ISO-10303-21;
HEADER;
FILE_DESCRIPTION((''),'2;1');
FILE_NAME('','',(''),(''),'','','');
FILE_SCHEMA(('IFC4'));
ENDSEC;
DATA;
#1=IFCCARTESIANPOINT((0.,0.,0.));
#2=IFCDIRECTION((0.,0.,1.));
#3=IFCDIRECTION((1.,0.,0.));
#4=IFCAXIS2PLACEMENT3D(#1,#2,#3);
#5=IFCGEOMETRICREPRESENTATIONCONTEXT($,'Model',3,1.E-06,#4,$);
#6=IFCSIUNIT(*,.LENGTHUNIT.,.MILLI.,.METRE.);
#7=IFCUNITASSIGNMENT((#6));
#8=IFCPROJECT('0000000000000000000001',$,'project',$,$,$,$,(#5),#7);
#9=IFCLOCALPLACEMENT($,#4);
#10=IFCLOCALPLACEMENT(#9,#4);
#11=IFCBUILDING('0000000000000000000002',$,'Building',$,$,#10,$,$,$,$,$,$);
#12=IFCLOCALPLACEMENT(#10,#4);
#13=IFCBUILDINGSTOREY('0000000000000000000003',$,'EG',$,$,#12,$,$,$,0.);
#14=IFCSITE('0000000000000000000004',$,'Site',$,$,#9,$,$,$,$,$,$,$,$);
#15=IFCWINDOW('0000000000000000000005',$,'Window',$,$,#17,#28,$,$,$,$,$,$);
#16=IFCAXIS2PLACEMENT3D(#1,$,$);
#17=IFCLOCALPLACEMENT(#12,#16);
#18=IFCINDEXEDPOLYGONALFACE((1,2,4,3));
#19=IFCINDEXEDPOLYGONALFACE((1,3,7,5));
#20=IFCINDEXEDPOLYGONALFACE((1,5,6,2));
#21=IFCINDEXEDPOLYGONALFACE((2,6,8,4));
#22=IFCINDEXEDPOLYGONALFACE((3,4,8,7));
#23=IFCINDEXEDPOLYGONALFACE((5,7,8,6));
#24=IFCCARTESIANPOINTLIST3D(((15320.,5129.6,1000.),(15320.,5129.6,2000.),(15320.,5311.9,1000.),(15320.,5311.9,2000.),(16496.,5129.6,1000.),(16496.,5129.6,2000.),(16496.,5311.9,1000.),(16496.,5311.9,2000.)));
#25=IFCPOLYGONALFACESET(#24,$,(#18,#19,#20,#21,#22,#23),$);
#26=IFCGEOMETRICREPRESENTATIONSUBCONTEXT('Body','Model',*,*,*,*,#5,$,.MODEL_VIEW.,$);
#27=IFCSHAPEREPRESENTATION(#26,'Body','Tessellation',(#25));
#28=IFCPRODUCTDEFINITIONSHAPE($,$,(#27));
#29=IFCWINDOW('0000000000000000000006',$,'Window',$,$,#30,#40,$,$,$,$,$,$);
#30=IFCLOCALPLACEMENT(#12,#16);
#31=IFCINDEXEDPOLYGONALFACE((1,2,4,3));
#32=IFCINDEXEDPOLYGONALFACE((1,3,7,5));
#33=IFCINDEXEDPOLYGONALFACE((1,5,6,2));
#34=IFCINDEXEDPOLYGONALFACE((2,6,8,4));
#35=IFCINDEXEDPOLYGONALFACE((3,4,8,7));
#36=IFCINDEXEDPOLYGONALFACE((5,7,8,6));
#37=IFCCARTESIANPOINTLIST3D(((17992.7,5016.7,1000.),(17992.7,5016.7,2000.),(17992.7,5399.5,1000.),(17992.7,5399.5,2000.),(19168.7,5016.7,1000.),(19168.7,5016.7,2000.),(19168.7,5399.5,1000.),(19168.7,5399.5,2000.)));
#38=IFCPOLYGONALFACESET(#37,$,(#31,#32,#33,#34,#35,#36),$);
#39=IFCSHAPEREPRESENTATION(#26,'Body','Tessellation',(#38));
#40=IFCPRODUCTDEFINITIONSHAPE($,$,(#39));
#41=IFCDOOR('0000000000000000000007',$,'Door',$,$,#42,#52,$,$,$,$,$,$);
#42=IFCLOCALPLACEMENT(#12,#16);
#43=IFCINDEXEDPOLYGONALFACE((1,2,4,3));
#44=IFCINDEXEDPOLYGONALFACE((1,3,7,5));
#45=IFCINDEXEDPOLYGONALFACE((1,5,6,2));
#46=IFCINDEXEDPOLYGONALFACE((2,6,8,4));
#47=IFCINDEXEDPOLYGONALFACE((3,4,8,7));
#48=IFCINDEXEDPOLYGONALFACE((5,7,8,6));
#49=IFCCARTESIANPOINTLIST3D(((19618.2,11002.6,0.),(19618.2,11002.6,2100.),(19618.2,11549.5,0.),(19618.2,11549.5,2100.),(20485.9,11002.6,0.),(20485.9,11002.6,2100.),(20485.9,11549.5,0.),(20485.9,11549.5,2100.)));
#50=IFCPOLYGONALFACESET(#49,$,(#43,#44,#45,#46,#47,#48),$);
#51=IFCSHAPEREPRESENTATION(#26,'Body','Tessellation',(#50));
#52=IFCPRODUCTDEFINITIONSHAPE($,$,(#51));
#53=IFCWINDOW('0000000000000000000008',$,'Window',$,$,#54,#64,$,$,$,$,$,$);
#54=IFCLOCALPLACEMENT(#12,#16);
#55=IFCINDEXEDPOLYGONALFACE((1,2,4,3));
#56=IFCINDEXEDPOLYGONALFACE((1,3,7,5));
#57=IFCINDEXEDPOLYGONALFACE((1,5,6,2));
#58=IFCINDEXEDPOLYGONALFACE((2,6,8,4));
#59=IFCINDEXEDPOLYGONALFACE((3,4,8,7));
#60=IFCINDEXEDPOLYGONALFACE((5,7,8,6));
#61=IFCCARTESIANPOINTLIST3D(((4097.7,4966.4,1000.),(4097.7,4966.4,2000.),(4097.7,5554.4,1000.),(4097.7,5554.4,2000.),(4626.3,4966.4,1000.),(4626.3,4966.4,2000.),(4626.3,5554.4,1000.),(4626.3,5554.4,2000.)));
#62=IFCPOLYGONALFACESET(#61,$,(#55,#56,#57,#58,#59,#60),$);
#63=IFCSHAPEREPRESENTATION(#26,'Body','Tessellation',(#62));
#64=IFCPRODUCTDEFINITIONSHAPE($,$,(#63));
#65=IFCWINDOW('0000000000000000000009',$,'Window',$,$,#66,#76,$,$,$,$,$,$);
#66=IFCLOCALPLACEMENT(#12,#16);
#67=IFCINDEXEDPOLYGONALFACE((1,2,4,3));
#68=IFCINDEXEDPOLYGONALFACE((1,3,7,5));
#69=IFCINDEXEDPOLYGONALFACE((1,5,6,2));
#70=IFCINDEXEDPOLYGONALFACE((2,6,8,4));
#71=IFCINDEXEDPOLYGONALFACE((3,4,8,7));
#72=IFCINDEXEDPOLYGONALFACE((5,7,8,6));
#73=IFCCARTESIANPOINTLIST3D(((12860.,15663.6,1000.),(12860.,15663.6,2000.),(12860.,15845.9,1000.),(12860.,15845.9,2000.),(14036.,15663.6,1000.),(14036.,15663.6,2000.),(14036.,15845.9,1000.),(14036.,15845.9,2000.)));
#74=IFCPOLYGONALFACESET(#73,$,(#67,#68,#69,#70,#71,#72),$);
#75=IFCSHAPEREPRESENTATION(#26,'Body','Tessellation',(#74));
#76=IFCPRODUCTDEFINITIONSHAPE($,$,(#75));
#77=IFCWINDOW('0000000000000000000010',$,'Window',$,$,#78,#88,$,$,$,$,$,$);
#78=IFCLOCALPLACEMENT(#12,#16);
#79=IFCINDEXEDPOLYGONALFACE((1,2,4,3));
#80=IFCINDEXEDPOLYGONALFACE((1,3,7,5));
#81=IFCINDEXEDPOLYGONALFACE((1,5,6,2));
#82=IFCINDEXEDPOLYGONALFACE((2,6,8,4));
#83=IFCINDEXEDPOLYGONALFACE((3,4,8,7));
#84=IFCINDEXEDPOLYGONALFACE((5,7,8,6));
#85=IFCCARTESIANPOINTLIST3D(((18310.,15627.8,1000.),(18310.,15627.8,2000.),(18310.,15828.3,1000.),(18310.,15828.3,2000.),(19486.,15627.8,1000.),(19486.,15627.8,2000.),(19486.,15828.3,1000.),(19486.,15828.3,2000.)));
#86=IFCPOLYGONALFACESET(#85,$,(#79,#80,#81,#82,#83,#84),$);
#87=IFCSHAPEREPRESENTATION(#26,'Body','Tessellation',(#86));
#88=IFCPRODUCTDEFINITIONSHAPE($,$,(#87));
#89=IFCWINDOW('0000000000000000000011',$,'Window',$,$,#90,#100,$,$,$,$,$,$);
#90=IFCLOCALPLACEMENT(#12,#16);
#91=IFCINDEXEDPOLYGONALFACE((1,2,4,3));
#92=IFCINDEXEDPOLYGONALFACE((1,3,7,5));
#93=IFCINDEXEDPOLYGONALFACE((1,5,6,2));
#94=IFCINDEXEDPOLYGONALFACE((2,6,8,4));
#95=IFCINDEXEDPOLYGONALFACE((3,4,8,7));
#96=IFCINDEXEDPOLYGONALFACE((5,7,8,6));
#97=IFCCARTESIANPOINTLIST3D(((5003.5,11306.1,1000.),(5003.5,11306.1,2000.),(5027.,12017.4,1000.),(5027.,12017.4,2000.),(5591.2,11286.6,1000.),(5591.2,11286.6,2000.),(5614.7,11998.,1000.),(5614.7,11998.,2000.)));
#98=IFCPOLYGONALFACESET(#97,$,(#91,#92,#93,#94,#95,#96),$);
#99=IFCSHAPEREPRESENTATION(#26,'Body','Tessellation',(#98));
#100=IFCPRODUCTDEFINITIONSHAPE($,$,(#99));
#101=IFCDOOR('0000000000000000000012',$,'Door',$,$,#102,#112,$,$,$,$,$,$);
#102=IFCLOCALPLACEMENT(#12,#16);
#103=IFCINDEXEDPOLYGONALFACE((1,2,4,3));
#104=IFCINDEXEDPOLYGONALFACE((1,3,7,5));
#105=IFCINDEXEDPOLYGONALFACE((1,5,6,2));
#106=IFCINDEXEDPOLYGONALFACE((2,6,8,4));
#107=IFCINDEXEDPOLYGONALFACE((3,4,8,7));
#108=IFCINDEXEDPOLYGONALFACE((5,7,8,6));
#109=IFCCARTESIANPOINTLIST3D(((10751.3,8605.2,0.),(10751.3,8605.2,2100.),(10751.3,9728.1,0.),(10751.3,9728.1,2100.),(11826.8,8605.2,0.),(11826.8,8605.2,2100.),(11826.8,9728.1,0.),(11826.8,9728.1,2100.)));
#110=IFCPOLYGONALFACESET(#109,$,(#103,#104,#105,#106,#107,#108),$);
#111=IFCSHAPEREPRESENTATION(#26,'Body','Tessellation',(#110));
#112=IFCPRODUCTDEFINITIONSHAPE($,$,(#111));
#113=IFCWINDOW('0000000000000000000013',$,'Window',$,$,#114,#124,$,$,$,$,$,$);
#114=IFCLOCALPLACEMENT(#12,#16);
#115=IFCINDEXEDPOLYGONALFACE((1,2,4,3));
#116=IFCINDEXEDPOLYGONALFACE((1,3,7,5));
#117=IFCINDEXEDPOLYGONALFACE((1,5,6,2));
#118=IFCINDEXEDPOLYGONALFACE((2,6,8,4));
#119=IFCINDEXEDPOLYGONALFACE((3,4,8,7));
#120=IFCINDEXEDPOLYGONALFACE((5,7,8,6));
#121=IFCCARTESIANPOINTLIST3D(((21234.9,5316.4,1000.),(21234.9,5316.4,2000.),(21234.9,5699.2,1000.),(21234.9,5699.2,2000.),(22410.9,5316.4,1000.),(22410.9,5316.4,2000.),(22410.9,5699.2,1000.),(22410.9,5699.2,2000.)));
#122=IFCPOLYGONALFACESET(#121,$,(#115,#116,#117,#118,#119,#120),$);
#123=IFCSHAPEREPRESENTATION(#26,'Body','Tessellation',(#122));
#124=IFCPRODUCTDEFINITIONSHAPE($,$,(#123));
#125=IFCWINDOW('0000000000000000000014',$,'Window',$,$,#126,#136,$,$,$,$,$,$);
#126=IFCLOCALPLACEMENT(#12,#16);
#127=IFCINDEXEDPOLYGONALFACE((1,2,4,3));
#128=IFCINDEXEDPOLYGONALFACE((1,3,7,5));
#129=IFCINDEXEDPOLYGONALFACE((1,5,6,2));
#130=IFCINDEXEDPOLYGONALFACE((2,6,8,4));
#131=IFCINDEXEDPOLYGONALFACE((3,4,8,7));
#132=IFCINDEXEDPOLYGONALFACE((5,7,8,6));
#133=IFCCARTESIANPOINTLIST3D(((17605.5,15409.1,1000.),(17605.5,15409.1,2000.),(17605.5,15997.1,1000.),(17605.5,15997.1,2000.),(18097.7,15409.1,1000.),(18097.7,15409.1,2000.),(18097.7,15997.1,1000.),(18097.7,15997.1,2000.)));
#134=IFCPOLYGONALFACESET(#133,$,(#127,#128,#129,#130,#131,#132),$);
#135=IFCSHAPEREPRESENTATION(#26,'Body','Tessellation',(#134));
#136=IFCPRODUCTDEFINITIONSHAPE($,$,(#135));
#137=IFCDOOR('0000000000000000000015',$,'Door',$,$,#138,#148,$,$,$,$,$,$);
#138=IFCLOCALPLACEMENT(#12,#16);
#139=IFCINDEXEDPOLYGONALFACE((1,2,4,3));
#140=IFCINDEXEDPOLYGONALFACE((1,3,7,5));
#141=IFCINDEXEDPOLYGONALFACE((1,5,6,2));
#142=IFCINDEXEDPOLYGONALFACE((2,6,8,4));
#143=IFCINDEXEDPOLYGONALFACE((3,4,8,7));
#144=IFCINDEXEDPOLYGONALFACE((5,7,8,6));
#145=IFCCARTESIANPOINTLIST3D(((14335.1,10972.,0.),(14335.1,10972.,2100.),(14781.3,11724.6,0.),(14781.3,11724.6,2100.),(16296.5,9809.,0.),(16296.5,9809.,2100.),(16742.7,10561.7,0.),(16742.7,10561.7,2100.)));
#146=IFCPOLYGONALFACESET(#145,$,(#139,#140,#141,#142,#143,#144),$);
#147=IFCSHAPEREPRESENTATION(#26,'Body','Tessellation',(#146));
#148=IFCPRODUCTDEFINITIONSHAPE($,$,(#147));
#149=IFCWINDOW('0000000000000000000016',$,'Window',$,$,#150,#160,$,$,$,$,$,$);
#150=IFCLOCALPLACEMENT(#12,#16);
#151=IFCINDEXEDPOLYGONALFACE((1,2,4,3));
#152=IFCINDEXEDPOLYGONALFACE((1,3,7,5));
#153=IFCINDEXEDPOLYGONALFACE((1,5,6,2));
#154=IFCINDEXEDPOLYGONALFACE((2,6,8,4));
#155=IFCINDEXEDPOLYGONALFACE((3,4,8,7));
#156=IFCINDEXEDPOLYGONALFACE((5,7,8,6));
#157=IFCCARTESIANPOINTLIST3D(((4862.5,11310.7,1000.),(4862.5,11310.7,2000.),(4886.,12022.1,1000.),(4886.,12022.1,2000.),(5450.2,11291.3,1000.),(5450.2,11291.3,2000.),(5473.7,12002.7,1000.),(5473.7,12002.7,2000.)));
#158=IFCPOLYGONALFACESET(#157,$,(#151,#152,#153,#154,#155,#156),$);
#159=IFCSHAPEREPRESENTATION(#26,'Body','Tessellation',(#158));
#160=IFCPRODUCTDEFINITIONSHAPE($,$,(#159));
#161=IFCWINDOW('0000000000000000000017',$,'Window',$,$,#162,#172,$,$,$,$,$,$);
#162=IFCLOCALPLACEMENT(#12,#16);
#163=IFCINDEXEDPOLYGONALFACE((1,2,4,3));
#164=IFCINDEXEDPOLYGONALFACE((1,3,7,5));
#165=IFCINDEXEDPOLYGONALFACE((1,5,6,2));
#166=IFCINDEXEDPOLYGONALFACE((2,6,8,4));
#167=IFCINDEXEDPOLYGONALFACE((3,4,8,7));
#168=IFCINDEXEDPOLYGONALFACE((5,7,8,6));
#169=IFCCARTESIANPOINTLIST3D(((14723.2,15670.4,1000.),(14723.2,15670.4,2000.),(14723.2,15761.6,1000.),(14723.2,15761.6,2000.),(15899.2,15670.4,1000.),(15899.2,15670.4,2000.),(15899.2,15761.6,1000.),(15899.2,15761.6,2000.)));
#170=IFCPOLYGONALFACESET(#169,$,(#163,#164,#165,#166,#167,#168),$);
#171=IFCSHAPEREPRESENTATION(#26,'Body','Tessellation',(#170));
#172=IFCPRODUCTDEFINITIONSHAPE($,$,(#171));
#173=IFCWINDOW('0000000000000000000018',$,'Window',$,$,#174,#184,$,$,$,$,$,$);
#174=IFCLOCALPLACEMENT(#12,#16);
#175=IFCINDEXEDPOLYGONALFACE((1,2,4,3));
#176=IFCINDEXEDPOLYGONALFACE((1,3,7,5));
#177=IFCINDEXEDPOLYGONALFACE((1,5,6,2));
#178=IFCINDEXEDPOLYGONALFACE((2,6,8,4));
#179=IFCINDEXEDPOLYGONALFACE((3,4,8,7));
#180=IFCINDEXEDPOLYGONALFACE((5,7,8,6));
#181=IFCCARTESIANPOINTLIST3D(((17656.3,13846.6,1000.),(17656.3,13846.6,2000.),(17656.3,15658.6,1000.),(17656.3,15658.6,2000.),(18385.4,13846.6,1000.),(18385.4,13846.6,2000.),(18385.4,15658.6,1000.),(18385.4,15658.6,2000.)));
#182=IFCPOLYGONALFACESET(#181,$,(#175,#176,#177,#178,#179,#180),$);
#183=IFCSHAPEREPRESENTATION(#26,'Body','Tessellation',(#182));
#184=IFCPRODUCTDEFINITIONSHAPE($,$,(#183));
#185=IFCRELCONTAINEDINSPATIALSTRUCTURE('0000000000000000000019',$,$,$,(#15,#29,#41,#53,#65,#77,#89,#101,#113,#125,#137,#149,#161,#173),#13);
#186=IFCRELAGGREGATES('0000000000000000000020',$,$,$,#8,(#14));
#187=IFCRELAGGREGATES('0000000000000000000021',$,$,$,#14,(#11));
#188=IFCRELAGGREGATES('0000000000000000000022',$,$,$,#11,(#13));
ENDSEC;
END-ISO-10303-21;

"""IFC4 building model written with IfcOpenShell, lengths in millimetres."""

from ifc_helpers import new_model, si_unit, frame, origin_with_axes, place, context, subcontext, project, spatial, rectangle, extrude, element, save


model = new_model("IFC4")

# Units and contexts
model_context = context("Model", 3, precision=1e-06, world=origin_with_axes())
body_context = subcontext(model_context, "Body", "Model", "MODEL_VIEW")
ifc_project = project(units=[si_unit("LENGTHUNIT", "METRE", prefix="MILLI")], contexts=[model_context])

# Site, building, storey
site_placement = place(None, origin_with_axes())
site = spatial("IfcSite", under=ifc_project, at=site_placement, Name="Site")
building_placement = place(site_placement, origin_with_axes())
building = spatial("IfcBuilding", under=site, at=building_placement, Name="Building")
storey_placement = place(building_placement, origin_with_axes())
storey = spatial("IfcBuildingStorey", under=building, at=storey_placement, Name="EG", Elevation=0.0)

# Windows
window_1_placement = place(storey_placement, origin_with_axes())
element("IfcWindow", 1, at=window_1_placement, inside=storey, Name="Window", context=body_context, shape_type="SweptSolid", body=[
    extrude(rectangle(XDim=1176.0, YDim=182.3), frame((15908.0, 5220.7, 1000.0), z_axis=(0.0, 0.0, 1.0), x_axis=(1.0, 0.0, 0.0)), (0.0, 0.0, 1.0), 1000.0),
])
window_2_placement = place(storey_placement, origin_with_axes())
element("IfcWindow", 2, at=window_2_placement, inside=storey, Name="Window", context=body_context, shape_type="SweptSolid", body=[
    extrude(rectangle(XDim=1176.0, YDim=382.8), frame((18580.7, 5208.1, 1000.0), z_axis=(0.0, 0.0, 1.0), x_axis=(1.0, 0.0, 0.0)), (0.0, 0.0, 1.0), 1000.0),
])

# Door
door_1_placement = place(storey_placement, origin_with_axes())
element("IfcDoor", 3, at=door_1_placement, inside=storey, Name="Door", context=body_context, shape_type="SweptSolid", body=[
    extrude(rectangle(XDim=867.7, YDim=546.9), frame((20052.1, 11276.0, 0.0), z_axis=(0.0, 0.0, 1.0), x_axis=(1.0, 0.0, 0.0)), (0.0, 0.0, 1.0), 2100.0),
])

# Windows
window_3_placement = place(storey_placement, origin_with_axes())
element("IfcWindow", 4, at=window_3_placement, inside=storey, Name="Window", context=body_context, shape_type="SweptSolid", body=[
    extrude(rectangle(XDim=588.0, YDim=528.6), frame((4362.0, 5260.4, 1000.0), z_axis=(0.0, 0.0, 1.0), x_axis=(0.0, 1.0, 0.0)), (0.0, 0.0, 1.0), 1000.0),
])
window_4_placement = place(storey_placement, origin_with_axes())
element("IfcWindow", 5, at=window_4_placement, inside=storey, Name="Window", context=body_context, shape_type="SweptSolid", body=[
    extrude(rectangle(XDim=1176.0, YDim=182.3), frame((13448.0, 15754.8, 1000.0), z_axis=(0.0, 0.0, 1.0), x_axis=(1.0, 0.0, 0.0)), (0.0, 0.0, 1.0), 1000.0),
])
window_5_placement = place(storey_placement, origin_with_axes())
element("IfcWindow", 6, at=window_5_placement, inside=storey, Name="Window", context=body_context, shape_type="SweptSolid", body=[
    extrude(rectangle(XDim=1176.0, YDim=200.5), frame((18898.0, 15728.1, 1000.0), z_axis=(0.0, 0.0, 1.0), x_axis=(1.0, 0.0, 0.0)), (0.0, 0.0, 1.0), 1000.0),
])
window_6_placement = place(storey_placement, origin_with_axes())
element("IfcWindow", 7, at=window_6_placement, inside=storey, Name="Window", context=body_context, shape_type="SweptSolid", body=[
    extrude(rectangle(XDim=588.0, YDim=711.8), frame((5309.1, 11652.0, 1000.0), z_axis=(0.0, 0.0, 1.0), x_axis=(-0.999454, 0.03304, 0.0)), (0.0, 0.0, 1.0), 1000.0),
])

# Door
door_2_placement = place(storey_placement, origin_with_axes())
element("IfcDoor", 8, at=door_2_placement, inside=storey, Name="Door", context=body_context, shape_type="SweptSolid", body=[
    extrude(rectangle(XDim=1122.9, YDim=1075.5), frame((11289.1, 9166.7, 0.0), z_axis=(0.0, 0.0, 1.0), x_axis=(0.0, 1.0, 0.0)), (0.0, 0.0, 1.0), 2100.0),
])

# Windows
window_7_placement = place(storey_placement, origin_with_axes())
element("IfcWindow", 9, at=window_7_placement, inside=storey, Name="Window", context=body_context, shape_type="SweptSolid", body=[
    extrude(rectangle(XDim=1176.0, YDim=382.8), frame((21822.9, 5507.8, 1000.0), z_axis=(0.0, 0.0, 1.0), x_axis=(1.0, 0.0, 0.0)), (0.0, 0.0, 1.0), 1000.0),
])
window_8_placement = place(storey_placement, origin_with_axes())
element("IfcWindow", 10, at=window_8_placement, inside=storey, Name="Window", context=body_context, shape_type="SweptSolid", body=[
    extrude(rectangle(XDim=588.0, YDim=492.2), frame((17851.6, 15703.1, 1000.0), z_axis=(0.0, 0.0, 1.0), x_axis=(0.0, 1.0, 0.0)), (0.0, 0.0, 1.0), 1000.0),
])

# Door
door_3_placement = place(storey_placement, origin_with_axes())
element("IfcDoor", 11, at=door_3_placement, inside=storey, Name="Door", context=body_context, shape_type="SweptSolid", body=[
    extrude(rectangle(XDim=875.0, YDim=2280.3), frame((15538.9, 10766.8, 0.0), z_axis=(0.0, 0.0, 1.0), x_axis=(-0.510011, -0.860168, 0.0)), (0.0, 0.0, 1.0), 2100.0),
])

# Windows
window_9_placement = place(storey_placement, origin_with_axes())
element("IfcWindow", 12, at=window_9_placement, inside=storey, Name="Window", context=body_context, shape_type="SweptSolid", body=[
    extrude(rectangle(XDim=588.0, YDim=711.8), frame((5168.1, 11656.7, 1000.0), z_axis=(0.0, 0.0, 1.0), x_axis=(-0.999454, 0.03304, 0.0)), (0.0, 0.0, 1.0), 1000.0),
])
window_10_placement = place(storey_placement, origin_with_axes())
element("IfcWindow", 13, at=window_10_placement, inside=storey, Name="Window", context=body_context, shape_type="SweptSolid", body=[
    extrude(rectangle(XDim=1176.0, YDim=91.1), frame((15311.2, 15716.0, 1000.0), z_axis=(0.0, 0.0, 1.0), x_axis=(1.0, 0.0, 0.0)), (0.0, 0.0, 1.0), 1000.0),
])
window_11_placement = place(storey_placement, origin_with_axes())
element("IfcWindow", 14, at=window_11_placement, inside=storey, Name="Window", context=body_context, shape_type="SweptSolid", body=[
    extrude(rectangle(XDim=1812.0, YDim=729.2), frame((18020.8, 14752.6, 1000.0), z_axis=(0.0, 0.0, 1.0), x_axis=(0.0, 1.0, 0.0)), (0.0, 0.0, 1.0), 1000.0),
])

save(model, "model.ifc")
